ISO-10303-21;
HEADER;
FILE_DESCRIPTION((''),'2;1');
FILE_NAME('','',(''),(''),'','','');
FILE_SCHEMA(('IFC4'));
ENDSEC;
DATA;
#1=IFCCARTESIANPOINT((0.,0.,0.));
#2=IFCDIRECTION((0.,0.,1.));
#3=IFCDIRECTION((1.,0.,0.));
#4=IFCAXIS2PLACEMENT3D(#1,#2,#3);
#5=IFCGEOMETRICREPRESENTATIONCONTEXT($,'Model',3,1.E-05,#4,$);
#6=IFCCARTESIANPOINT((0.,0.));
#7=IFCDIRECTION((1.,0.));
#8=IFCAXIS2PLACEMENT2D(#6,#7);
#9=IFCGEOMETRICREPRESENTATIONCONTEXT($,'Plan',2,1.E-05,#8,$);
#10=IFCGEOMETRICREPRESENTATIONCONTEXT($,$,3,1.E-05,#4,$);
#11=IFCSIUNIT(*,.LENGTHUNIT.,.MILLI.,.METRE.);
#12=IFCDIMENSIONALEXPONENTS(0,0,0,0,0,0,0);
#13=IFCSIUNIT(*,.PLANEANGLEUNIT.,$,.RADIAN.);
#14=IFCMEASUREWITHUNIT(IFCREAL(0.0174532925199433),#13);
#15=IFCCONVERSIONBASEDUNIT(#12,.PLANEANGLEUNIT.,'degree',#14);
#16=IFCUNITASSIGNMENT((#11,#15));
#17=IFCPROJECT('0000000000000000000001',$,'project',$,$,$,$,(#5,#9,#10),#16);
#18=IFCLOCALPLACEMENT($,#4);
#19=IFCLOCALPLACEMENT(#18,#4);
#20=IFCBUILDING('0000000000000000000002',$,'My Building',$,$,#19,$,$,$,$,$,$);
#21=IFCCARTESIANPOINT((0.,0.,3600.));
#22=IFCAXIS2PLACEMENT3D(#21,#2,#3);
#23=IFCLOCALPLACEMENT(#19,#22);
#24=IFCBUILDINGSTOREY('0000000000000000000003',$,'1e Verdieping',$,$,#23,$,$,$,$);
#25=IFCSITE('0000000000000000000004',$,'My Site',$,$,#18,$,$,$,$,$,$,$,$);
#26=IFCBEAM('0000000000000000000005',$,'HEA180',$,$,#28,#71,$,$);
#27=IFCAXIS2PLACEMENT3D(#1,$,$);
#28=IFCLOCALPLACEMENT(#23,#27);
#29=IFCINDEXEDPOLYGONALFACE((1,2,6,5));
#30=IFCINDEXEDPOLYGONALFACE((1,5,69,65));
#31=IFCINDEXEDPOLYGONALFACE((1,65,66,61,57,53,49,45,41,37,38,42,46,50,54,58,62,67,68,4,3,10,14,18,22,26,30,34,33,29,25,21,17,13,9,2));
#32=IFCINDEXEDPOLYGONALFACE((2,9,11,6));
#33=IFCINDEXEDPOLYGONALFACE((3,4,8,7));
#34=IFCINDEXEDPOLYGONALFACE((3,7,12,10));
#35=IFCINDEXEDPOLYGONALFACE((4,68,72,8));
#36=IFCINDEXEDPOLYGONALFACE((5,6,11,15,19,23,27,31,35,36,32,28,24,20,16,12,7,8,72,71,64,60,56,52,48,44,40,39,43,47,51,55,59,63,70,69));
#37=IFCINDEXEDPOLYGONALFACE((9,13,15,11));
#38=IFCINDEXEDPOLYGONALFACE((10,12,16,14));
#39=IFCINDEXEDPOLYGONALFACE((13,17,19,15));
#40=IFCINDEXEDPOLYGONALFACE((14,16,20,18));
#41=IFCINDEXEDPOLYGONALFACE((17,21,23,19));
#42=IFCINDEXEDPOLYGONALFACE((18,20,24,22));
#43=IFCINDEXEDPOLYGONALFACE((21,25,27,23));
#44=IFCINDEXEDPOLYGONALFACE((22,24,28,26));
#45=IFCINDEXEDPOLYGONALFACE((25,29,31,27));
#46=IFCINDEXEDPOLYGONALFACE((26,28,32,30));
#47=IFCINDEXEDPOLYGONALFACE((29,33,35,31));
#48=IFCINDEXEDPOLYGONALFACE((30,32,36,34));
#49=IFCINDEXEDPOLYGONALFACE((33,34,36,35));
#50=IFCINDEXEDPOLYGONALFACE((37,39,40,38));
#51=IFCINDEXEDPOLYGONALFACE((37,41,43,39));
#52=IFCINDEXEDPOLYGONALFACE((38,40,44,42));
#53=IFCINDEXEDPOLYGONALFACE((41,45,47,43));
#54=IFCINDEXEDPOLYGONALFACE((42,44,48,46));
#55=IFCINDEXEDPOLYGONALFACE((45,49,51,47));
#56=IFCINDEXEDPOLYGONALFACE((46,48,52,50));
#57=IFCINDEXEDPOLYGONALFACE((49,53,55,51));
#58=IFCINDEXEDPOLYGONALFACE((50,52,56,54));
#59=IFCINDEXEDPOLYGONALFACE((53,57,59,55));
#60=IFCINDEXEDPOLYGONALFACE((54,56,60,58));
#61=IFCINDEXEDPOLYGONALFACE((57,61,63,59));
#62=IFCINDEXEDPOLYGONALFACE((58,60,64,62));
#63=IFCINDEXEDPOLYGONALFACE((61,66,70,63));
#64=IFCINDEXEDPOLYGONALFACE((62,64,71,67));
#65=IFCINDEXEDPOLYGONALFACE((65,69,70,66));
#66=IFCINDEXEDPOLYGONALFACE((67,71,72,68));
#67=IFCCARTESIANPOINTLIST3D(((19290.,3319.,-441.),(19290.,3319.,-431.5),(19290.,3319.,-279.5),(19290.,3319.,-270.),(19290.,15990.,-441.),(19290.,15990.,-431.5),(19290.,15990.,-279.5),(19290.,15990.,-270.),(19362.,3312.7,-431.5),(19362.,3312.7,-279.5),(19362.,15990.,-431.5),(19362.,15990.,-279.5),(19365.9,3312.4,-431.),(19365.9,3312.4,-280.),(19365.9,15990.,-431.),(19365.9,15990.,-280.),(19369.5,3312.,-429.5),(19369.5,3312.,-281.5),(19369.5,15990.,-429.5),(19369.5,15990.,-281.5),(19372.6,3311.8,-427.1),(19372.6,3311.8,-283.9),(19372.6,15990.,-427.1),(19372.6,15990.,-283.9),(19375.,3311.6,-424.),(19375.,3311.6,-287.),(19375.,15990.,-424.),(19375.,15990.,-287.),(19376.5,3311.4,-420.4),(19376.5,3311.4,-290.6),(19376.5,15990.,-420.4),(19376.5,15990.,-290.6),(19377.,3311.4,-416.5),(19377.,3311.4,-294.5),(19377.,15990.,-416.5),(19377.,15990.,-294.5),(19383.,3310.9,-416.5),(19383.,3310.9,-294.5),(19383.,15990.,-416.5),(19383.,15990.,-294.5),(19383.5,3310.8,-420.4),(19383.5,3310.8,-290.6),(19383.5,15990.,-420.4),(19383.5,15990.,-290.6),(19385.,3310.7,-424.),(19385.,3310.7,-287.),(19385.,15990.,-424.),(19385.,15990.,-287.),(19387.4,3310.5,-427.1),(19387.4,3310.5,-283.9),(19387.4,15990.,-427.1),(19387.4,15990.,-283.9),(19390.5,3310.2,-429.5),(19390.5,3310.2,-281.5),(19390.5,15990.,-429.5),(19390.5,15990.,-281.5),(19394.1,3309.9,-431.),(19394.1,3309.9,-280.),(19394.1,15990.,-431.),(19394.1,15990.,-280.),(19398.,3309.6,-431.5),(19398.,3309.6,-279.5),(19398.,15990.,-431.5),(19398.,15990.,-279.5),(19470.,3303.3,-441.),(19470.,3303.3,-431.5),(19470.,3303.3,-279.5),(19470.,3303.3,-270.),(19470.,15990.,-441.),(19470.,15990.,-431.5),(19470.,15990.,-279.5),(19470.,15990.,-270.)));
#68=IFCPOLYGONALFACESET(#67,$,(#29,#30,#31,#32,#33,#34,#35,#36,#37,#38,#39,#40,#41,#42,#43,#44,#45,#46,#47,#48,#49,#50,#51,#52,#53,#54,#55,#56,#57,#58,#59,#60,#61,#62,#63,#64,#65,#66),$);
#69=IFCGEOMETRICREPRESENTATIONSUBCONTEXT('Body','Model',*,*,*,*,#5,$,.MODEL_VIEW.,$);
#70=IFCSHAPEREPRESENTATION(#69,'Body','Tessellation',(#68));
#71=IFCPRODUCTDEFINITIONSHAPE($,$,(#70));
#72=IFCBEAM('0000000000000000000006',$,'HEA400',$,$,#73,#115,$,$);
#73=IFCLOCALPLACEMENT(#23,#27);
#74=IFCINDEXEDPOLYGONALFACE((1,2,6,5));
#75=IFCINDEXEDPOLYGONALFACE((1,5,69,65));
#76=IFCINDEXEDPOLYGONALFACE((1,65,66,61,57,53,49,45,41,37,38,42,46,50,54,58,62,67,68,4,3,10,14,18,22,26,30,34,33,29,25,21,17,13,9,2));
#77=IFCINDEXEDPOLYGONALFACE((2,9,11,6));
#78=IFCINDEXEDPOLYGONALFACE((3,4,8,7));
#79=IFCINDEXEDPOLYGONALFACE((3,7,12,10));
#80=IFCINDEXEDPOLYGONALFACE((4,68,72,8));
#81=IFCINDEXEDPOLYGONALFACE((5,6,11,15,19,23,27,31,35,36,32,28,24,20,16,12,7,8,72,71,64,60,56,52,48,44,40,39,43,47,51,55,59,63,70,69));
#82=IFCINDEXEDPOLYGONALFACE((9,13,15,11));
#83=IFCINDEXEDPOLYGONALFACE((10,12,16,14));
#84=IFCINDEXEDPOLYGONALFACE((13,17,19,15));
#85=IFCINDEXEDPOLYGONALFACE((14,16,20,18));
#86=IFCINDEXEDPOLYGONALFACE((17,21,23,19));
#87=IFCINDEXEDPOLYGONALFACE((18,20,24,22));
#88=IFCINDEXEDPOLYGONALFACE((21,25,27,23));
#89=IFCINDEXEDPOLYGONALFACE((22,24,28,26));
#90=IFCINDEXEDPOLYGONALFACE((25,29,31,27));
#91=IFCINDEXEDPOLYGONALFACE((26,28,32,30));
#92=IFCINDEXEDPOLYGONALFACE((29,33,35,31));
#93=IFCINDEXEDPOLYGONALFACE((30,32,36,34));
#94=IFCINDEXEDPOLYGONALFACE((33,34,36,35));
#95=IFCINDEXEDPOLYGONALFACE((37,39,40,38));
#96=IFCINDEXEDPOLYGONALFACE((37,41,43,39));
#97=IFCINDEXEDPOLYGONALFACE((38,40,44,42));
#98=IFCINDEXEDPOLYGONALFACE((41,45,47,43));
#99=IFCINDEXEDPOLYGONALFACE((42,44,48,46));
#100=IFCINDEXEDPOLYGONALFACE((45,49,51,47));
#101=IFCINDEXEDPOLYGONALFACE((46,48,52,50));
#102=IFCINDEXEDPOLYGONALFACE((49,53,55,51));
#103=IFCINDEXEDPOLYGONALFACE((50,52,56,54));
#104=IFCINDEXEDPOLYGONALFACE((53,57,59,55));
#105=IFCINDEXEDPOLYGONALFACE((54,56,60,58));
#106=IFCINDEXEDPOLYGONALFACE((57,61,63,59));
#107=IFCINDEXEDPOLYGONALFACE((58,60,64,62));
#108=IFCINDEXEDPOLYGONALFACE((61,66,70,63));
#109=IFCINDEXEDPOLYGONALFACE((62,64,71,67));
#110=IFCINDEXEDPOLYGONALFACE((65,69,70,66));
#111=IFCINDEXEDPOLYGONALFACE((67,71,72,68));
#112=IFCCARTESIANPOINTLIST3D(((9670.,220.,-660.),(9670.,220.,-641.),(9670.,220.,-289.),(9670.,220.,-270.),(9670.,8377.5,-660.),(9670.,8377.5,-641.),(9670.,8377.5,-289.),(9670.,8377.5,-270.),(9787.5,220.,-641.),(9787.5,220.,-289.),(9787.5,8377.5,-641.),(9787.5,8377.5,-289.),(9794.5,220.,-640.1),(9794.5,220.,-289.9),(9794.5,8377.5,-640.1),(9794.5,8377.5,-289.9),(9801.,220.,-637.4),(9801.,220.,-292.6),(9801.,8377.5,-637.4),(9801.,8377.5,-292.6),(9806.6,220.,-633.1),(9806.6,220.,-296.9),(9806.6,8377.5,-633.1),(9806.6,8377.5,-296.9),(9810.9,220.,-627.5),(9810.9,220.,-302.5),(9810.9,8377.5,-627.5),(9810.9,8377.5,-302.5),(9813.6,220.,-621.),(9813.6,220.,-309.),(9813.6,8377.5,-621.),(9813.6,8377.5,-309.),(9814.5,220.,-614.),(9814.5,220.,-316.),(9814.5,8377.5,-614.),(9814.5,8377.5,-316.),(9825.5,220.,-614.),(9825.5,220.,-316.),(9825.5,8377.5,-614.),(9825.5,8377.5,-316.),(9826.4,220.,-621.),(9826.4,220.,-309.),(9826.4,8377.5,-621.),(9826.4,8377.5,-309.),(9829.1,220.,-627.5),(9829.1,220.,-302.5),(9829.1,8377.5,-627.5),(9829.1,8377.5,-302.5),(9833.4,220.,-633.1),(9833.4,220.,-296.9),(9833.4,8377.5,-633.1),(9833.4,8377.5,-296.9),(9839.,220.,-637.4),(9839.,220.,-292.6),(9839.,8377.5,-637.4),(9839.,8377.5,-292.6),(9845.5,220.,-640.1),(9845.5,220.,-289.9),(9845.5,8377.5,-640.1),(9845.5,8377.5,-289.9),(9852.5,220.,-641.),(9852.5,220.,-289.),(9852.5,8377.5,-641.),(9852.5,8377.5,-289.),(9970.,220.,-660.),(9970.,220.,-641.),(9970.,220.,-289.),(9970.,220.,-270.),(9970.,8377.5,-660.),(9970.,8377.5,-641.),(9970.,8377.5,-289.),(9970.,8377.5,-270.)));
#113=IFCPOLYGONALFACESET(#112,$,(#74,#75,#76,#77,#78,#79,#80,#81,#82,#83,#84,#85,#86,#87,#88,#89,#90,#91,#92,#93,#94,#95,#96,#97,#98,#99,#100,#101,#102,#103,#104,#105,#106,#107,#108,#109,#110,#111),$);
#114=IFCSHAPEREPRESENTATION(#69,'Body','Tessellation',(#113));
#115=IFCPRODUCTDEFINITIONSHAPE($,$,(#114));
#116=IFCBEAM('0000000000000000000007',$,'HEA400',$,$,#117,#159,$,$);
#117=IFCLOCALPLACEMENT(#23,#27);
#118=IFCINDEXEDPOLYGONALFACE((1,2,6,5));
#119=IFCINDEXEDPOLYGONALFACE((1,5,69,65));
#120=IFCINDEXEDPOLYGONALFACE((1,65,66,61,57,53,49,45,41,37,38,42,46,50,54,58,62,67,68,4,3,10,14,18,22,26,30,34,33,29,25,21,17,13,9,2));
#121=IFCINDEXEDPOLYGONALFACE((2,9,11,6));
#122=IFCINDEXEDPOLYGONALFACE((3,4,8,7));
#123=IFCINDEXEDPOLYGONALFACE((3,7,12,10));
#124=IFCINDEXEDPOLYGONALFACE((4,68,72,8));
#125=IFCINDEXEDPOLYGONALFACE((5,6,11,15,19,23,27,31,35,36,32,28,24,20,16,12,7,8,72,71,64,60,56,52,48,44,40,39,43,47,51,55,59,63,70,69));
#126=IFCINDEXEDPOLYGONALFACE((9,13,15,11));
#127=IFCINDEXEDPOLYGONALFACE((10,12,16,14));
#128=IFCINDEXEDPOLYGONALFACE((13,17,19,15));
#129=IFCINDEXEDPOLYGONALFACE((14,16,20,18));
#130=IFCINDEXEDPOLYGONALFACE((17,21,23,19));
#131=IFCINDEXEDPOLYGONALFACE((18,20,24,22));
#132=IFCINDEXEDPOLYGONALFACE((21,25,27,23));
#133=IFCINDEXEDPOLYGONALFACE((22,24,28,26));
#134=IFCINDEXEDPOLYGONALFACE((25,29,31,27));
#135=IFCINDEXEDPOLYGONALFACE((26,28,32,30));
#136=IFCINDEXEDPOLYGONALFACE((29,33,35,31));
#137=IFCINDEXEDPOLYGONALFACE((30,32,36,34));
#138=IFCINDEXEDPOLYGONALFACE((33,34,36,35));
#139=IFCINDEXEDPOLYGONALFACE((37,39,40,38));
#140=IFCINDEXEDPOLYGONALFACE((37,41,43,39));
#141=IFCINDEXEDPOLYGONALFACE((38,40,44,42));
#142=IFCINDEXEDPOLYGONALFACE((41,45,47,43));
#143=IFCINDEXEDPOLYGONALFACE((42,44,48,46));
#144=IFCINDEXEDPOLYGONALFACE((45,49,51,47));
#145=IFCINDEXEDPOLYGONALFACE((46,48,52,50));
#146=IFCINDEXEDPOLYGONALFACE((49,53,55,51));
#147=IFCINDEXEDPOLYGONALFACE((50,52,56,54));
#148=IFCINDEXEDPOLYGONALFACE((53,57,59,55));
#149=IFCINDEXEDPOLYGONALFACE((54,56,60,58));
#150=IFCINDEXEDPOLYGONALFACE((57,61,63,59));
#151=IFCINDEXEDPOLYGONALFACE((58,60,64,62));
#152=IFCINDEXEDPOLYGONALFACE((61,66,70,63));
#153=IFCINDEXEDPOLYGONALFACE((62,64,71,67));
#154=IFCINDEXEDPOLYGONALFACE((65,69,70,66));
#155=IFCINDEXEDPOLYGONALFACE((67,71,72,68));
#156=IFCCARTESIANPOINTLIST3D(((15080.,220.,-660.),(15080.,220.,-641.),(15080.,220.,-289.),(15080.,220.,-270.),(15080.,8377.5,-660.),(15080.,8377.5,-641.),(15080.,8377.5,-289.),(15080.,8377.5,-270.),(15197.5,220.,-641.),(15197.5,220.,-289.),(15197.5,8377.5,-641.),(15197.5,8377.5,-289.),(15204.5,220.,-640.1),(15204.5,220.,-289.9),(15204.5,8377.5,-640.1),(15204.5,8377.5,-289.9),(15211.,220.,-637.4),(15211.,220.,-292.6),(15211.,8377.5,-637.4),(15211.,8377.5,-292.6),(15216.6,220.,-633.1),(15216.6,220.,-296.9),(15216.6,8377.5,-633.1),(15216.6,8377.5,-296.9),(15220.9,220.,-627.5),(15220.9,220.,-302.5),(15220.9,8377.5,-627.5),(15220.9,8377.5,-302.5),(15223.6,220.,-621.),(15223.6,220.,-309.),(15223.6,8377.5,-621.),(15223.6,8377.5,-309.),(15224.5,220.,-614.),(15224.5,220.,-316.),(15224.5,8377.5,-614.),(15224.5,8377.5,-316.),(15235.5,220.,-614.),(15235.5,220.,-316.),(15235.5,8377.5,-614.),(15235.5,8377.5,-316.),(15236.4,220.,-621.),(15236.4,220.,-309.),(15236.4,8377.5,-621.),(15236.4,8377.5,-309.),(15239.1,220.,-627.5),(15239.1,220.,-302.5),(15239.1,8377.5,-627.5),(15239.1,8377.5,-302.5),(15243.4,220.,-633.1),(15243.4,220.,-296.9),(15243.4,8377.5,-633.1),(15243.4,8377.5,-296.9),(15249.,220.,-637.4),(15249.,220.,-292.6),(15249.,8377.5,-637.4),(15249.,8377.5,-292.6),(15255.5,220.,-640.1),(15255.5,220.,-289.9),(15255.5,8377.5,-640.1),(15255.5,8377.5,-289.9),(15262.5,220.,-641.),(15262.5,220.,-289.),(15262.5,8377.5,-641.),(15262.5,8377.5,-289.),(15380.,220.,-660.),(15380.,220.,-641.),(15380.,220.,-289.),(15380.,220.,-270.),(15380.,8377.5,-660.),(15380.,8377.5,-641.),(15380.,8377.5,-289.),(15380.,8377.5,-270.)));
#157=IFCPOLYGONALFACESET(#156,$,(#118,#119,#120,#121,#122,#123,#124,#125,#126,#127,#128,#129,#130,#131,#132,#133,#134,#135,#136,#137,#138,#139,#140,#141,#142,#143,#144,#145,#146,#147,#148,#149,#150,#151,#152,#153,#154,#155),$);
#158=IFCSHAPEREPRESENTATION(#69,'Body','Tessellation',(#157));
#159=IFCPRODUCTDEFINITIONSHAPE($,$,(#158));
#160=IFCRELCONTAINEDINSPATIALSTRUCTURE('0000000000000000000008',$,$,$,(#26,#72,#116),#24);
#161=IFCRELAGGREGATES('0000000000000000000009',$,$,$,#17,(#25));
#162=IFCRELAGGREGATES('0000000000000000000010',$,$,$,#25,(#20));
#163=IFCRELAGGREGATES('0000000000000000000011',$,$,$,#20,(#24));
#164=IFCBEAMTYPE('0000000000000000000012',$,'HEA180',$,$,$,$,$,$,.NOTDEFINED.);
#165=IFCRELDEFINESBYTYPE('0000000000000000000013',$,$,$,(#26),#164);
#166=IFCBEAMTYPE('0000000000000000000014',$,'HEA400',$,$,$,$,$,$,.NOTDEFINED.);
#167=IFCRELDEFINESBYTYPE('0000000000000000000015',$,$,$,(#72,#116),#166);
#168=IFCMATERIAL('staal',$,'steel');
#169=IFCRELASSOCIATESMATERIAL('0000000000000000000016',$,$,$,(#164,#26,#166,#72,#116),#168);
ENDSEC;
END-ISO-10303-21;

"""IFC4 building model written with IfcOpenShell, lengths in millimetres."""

from ifc_helpers import new_model, entity, si_unit, converted_unit, frame, origin_with_axes, origin_2d_with_axis, place, context, subcontext, project, spatial, i_section, extrude, clip, halfspace, material, material_profile, profile_set, profile_usage, type_object, element, save


model = new_model("IFC4")

# Units and contexts
model_context = context("Model", 3, precision=1e-05, world=origin_with_axes())
plan_context = context("Plan", 2, precision=1e-05, world=origin_2d_with_axis())
context_of_model = context(None, 3, precision=1e-05, world=origin_with_axes())
body_context = subcontext(model_context, "Body", "Model", "MODEL_VIEW")
ifc_project = project(units=[si_unit("LENGTHUNIT", "METRE", prefix="MILLI"), converted_unit("PLANEANGLEUNIT", "degree", entity("IfcReal", 0.0174532925199433), si_unit("PLANEANGLEUNIT", "RADIAN"), dimensions=[0, 0, 0, 0, 0, 0, 0])], contexts=[model_context, plan_context, context_of_model])

# Site, building, storey
site_placement = place(None, origin_with_axes())
site = spatial("IfcSite", under=ifc_project, at=site_placement, Name="My Site")
building_placement = place(site_placement, origin_with_axes())
building = spatial("IfcBuilding", under=site, at=building_placement, Name="My Building")
storey_placement = place(building_placement, frame((0.0, 0.0, 3600.0), z_axis=(0.0, 0.0, 1.0), x_axis=(1.0, 0.0, 0.0)))
storey = spatial("IfcBuildingStorey", under=building, at=storey_placement, Name="1e Verdieping")

# Shared definitions
ifc_material = material(Name="staal", Category="steel")

# Beams
ifc_material_profile_1 = material_profile(ifc_material, i_section(OverallWidth=180.0, OverallDepth=171.0, WebThickness=6.0, FlangeThickness=9.5, FilletRadius=15.0))
ifc_profile_set_1 = profile_set([ifc_material_profile_1], Name="HEA180")
beam_type_1 = type_object("IfcBeamType", Name="HEA180", PredefinedType="NOTDEFINED", material=ifc_profile_set_1)
ifc_profile_usage_1 = profile_usage(ifc_profile_set_1)
beam_1_placement = place(storey_placement, frame((19380.0, 15990.0, -355.5), z_axis=(0.0, -1.0, 0.0), x_axis=(1.0, 0.0, 0.0)))
element("IfcBeam", 1, at=beam_1_placement, inside=storey, type_object=beam_type_1, material=ifc_profile_usage_1, Name="HEA180", context=body_context, shape_type="Clipping", body=[
    clip(extrude(i_section(OverallWidth=180.0, OverallDepth=171.0, WebThickness=6.0, FlangeThickness=9.5, FilletRadius=15.0), origin_with_axes(), (0.0, 0.0, 1.0), 13377.2), halfspace(frame((90.0, -3244.5, 12686.7), z_axis=(-0.08708, 0.0, 0.996201), x_axis=(0.0, 1.0, 0.0)), False)),
])
ifc_material_profile_2 = material_profile(ifc_material, i_section(OverallWidth=300.0, OverallDepth=390.0, WebThickness=11.0, FlangeThickness=19.0, FilletRadius=27.0))
ifc_profile_set_2 = profile_set([ifc_material_profile_2], Name="HEA400")
ifc_profile_usage_2 = profile_usage(ifc_profile_set_2, cardinal=5)
beam_type_2 = type_object("IfcBeamType", Name="HEA400", PredefinedType="NOTDEFINED", material=ifc_profile_set_2)
beam_2_placement = place(storey_placement, frame((9820.0, 220.0, -465.0), z_axis=(0.0, 1.0, 0.0), x_axis=(-1.0, 0.0, 0.0)))
element("IfcBeam", 2, at=beam_2_placement, inside=storey, type_object=beam_type_2, material=ifc_profile_usage_2, Name="HEA400", context=body_context, shape_type="SweptSolid", body=[
    extrude(i_section(OverallWidth=300.0, OverallDepth=390.0, WebThickness=11.0, FlangeThickness=19.0, FilletRadius=27.0), origin_with_axes(), (0.0, 0.0, 1.0), 8157.5),
])
ifc_profile_usage_3 = profile_usage(ifc_profile_set_2, cardinal=5)
beam_3_placement = place(storey_placement, frame((15230.0, 220.0, -465.0), z_axis=(0.0, 1.0, 0.0), x_axis=(-1.0, 0.0, 0.0)))
element("IfcBeam", 3, at=beam_3_placement, inside=storey, type_object=beam_type_2, material=ifc_profile_usage_3, Name="HEA400", context=body_context, shape_type="SweptSolid", body=[
    extrude(i_section(OverallWidth=300.0, OverallDepth=390.0, WebThickness=11.0, FlangeThickness=19.0, FilletRadius=27.0), origin_with_axes(), (0.0, 0.0, 1.0), 8157.5),
])

save(model, "model.ifc")
